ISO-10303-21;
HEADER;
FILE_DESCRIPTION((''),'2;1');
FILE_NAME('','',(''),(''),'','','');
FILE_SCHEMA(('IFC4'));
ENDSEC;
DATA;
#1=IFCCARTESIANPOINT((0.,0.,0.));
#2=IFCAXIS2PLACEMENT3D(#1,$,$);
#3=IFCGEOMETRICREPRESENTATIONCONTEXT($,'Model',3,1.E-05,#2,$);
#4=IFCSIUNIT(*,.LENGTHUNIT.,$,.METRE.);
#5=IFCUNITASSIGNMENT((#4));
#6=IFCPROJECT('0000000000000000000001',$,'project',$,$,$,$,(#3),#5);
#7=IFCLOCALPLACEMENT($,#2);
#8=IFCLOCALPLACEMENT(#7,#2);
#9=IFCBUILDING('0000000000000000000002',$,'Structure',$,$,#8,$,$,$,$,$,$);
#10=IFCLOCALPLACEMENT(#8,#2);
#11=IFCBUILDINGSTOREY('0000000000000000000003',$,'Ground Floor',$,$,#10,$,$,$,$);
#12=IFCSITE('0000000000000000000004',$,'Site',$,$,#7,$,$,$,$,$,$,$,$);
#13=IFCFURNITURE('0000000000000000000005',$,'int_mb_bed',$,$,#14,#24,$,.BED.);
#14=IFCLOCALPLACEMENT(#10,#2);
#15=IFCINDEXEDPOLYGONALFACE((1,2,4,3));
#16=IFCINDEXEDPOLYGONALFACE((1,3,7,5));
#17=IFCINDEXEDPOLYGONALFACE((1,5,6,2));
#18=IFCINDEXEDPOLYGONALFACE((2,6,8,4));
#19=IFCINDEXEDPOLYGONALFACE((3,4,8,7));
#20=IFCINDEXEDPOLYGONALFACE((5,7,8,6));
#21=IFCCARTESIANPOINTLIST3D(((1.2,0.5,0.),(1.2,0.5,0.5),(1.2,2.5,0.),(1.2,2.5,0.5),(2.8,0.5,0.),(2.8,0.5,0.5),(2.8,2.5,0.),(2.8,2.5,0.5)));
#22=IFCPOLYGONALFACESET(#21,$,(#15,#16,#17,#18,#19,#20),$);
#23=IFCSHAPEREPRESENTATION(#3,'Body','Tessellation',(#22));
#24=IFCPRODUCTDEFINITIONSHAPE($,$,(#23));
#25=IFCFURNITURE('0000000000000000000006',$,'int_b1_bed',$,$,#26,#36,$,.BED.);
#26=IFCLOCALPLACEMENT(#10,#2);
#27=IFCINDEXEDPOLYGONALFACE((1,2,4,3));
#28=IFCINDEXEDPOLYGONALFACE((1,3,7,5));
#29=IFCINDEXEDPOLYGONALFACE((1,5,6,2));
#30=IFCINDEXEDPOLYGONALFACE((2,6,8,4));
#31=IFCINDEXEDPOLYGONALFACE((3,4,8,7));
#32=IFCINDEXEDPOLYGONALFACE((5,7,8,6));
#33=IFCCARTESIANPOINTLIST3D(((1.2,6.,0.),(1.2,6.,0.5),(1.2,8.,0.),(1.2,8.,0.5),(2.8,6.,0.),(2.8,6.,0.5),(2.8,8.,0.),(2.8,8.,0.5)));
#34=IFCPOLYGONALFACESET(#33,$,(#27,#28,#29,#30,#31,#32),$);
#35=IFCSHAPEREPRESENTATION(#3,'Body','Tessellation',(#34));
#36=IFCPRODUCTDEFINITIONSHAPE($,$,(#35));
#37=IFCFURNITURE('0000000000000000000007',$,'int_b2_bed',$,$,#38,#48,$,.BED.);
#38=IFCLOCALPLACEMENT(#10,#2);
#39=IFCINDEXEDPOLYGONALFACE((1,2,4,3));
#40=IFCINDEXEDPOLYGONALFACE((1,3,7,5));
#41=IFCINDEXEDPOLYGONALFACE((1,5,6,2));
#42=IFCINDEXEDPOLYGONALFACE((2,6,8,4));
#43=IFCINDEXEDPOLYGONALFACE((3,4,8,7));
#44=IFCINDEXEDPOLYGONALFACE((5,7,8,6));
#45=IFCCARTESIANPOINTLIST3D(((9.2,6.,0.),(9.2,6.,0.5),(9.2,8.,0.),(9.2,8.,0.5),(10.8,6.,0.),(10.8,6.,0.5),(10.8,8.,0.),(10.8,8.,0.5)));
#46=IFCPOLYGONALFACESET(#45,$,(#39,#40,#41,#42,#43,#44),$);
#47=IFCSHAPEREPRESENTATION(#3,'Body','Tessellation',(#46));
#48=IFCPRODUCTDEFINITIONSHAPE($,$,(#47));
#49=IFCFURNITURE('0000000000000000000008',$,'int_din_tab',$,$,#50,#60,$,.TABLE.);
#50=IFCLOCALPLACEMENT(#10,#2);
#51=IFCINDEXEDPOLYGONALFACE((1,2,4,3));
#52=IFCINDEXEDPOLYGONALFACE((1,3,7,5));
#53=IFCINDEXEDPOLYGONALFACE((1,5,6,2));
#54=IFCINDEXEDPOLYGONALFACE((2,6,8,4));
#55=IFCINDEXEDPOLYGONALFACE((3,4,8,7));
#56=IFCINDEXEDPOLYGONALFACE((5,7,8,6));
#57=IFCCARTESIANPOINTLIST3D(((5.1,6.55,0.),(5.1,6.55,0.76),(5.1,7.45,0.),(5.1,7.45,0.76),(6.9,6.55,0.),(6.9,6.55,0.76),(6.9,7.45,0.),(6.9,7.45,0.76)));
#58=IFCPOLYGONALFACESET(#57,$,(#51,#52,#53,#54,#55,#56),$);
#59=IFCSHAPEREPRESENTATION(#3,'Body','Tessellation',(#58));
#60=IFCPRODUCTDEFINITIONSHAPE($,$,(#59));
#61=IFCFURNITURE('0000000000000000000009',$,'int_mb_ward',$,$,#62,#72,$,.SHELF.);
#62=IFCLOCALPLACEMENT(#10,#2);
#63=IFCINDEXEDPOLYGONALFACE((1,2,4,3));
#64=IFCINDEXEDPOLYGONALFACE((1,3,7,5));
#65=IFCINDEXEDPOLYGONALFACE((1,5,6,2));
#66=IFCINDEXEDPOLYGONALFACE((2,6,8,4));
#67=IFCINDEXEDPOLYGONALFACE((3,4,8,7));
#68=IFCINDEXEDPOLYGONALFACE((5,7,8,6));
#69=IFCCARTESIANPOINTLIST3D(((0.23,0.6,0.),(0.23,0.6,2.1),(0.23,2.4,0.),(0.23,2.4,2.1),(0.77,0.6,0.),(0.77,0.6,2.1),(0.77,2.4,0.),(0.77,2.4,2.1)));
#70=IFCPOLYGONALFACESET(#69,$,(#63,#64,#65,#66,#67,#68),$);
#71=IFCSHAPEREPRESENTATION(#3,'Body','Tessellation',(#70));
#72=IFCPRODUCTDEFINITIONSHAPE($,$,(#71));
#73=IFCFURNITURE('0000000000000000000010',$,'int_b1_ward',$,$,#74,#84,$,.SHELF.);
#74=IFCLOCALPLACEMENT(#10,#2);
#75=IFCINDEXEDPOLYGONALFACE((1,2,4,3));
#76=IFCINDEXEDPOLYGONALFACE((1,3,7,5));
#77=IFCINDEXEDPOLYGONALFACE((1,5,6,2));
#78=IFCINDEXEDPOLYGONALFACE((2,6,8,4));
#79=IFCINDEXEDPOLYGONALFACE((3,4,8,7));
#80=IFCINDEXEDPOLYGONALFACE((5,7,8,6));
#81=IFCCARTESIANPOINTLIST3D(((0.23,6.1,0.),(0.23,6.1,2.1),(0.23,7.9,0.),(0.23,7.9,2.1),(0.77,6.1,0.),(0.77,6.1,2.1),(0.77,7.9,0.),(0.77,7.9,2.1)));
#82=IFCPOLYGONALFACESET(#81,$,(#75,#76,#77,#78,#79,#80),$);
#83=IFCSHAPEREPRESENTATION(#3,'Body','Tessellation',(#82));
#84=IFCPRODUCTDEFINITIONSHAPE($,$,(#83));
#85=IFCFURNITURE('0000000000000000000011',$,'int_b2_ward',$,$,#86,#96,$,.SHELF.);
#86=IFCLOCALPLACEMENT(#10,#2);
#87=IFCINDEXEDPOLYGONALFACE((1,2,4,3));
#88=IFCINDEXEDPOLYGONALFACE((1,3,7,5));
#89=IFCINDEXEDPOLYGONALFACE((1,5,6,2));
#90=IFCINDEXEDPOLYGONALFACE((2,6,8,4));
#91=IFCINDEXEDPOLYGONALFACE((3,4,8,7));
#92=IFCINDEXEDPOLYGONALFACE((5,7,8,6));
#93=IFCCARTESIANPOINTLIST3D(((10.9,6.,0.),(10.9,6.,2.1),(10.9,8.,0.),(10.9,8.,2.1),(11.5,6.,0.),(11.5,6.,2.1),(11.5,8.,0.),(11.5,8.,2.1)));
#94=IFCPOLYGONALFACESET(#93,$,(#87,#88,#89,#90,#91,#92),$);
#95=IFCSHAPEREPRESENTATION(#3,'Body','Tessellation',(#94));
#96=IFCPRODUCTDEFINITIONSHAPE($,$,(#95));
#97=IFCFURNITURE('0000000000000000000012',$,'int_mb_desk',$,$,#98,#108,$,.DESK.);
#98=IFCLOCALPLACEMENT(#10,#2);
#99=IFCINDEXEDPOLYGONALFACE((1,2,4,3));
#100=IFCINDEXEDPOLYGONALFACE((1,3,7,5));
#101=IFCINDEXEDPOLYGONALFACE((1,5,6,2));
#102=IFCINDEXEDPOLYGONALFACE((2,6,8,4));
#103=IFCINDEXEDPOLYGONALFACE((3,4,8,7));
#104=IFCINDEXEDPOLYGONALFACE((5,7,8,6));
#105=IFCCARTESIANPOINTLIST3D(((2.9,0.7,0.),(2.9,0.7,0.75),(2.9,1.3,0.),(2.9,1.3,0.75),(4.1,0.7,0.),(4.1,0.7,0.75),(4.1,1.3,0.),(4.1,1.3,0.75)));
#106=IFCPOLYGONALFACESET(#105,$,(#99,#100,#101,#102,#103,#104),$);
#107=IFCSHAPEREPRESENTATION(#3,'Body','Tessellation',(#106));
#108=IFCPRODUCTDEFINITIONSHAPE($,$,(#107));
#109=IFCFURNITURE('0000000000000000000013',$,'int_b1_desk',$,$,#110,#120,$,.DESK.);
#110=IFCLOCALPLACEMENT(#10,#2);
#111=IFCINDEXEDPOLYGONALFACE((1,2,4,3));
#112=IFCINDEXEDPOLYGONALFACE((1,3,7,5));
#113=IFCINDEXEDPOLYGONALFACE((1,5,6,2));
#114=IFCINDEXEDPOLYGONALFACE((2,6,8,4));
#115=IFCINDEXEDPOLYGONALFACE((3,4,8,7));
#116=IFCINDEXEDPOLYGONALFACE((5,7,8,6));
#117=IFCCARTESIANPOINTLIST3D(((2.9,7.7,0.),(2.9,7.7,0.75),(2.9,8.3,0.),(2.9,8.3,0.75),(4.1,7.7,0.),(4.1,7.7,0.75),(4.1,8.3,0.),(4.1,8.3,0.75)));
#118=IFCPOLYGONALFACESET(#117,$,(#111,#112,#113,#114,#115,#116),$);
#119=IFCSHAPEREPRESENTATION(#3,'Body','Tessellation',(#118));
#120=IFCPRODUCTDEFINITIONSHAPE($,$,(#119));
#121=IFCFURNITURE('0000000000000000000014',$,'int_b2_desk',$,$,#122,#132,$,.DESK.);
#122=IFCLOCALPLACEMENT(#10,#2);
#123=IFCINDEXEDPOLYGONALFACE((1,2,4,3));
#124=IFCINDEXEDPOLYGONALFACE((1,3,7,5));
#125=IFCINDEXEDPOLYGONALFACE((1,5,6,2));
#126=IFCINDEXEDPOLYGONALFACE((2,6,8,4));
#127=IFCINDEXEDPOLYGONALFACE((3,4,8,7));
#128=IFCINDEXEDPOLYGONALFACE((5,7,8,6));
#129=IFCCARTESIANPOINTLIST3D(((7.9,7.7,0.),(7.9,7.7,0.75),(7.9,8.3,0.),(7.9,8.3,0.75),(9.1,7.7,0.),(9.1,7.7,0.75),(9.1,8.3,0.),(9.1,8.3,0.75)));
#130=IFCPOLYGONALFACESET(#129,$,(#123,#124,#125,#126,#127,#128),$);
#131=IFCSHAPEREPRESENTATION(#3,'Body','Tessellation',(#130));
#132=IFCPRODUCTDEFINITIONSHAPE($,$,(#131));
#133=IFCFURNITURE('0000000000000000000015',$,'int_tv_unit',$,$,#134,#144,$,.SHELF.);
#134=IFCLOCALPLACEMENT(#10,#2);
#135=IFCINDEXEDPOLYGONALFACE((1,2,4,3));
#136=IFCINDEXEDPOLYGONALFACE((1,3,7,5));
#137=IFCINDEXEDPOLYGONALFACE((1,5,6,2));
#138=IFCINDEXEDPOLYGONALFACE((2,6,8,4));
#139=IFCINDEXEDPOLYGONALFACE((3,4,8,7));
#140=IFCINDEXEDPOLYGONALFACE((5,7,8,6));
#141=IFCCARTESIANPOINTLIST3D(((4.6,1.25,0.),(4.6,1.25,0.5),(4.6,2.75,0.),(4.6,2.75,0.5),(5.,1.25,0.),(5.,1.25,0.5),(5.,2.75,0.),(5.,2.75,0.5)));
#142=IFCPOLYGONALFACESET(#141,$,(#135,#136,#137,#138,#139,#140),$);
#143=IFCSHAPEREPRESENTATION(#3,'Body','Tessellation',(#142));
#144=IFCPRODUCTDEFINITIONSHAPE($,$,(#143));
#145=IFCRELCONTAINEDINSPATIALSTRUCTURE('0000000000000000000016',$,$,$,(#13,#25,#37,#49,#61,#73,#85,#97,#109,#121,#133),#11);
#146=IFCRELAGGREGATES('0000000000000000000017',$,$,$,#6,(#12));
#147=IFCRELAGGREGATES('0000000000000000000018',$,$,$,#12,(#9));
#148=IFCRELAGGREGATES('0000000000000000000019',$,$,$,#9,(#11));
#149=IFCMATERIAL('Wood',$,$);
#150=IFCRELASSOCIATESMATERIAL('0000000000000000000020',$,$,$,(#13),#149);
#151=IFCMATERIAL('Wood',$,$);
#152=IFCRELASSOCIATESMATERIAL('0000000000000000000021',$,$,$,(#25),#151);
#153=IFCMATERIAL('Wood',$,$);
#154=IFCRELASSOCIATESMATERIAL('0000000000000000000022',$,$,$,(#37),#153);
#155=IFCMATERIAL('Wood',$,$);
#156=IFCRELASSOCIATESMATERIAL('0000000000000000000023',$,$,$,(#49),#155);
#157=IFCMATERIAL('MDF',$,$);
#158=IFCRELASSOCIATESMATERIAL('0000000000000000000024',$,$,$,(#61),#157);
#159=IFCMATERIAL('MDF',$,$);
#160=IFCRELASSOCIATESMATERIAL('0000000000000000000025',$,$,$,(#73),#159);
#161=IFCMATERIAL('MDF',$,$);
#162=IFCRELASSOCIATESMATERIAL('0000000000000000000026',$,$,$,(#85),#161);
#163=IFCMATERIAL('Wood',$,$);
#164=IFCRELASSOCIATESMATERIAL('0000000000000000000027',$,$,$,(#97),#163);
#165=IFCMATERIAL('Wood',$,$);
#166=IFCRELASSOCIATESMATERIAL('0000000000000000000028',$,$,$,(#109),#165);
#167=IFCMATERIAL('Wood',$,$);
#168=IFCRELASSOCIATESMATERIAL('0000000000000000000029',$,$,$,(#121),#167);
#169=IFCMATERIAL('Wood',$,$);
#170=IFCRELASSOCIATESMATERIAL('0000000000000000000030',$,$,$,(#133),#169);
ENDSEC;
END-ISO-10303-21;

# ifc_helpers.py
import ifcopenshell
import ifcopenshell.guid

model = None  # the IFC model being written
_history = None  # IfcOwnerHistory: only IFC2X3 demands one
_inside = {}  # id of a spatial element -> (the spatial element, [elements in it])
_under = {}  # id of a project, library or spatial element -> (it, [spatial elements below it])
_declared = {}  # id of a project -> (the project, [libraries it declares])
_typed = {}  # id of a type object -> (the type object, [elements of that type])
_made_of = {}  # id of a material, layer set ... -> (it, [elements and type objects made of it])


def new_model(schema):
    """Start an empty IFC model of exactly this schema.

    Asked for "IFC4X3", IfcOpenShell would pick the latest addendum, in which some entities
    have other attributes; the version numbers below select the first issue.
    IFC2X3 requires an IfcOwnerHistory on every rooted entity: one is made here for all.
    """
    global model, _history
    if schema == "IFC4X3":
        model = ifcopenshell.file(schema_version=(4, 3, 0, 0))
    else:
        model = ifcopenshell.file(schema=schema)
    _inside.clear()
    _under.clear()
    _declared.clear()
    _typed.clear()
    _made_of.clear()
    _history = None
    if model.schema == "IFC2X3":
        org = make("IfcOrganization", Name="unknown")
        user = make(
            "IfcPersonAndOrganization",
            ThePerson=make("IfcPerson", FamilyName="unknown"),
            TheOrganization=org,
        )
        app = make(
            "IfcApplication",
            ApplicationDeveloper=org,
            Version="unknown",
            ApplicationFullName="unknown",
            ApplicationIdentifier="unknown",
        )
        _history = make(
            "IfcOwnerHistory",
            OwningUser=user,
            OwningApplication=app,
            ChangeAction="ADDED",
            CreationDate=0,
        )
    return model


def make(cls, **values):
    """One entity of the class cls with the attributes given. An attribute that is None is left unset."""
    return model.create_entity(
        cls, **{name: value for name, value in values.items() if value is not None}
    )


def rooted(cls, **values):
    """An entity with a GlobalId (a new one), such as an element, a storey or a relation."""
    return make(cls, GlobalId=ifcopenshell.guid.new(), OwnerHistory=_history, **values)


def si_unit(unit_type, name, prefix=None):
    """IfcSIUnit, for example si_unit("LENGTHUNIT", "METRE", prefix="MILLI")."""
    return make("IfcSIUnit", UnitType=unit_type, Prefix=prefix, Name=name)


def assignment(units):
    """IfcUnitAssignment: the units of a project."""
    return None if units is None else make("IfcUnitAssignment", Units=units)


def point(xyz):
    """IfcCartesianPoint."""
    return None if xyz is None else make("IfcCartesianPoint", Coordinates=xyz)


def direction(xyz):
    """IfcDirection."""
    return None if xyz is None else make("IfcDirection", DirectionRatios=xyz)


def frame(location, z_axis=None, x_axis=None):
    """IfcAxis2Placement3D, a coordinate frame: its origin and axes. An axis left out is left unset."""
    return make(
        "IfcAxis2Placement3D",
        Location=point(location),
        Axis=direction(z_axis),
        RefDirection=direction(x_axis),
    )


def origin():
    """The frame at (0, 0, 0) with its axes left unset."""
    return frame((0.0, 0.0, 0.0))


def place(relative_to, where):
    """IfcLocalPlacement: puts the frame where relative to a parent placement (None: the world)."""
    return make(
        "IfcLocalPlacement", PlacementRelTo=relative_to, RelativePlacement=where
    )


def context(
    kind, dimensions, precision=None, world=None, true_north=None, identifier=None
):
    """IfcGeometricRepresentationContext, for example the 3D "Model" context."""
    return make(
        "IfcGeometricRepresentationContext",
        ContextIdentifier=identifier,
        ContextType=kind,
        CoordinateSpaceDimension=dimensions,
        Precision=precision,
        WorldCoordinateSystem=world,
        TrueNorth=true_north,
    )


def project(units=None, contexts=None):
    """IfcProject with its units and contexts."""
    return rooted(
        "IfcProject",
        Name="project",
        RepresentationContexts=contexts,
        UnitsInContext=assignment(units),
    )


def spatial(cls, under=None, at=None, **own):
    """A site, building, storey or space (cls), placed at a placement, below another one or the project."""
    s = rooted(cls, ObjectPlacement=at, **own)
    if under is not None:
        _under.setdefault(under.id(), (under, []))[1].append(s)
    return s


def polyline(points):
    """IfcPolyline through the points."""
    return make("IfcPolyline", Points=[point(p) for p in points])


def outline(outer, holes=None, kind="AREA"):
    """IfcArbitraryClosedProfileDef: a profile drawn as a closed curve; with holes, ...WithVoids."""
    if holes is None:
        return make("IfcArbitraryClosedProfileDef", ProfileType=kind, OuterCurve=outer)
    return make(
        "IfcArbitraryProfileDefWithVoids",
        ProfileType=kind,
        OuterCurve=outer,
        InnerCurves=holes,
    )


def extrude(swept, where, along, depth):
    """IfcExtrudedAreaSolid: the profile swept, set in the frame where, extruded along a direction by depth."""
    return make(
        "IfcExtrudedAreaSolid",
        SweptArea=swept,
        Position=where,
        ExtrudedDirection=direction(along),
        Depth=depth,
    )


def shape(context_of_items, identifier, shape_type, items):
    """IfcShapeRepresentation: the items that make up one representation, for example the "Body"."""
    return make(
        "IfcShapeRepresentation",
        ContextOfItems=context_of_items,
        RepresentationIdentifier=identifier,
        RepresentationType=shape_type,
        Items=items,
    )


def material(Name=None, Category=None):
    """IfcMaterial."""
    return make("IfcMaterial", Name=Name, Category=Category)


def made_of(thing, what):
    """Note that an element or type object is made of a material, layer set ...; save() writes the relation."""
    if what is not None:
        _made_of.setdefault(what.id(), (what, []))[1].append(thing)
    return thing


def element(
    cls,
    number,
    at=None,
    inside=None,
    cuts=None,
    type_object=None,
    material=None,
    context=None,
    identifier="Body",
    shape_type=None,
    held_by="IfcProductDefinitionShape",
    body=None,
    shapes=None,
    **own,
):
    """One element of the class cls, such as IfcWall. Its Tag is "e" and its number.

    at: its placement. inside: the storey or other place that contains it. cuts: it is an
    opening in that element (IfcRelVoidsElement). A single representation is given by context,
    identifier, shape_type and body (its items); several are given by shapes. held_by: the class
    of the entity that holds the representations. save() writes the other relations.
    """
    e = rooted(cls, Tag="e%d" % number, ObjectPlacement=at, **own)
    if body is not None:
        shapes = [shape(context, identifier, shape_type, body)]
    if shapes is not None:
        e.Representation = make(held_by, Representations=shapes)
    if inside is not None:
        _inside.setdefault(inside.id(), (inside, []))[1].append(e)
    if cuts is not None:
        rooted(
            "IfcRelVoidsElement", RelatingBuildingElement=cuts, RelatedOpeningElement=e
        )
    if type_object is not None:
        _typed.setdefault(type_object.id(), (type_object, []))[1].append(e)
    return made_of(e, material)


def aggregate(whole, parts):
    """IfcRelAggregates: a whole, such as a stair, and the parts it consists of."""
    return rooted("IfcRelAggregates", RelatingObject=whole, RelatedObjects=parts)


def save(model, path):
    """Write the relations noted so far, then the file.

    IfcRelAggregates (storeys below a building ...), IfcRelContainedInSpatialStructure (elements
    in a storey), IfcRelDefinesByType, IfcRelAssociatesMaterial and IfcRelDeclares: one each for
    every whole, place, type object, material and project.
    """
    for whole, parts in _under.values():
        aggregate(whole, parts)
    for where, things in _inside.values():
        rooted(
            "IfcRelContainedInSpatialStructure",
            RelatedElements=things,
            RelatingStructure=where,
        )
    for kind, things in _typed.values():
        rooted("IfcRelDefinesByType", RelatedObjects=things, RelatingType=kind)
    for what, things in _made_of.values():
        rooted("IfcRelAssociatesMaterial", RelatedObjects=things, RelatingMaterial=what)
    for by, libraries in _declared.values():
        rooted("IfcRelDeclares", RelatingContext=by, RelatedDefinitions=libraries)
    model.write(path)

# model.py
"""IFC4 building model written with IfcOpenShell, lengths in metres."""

from ifc_helpers import new_model, si_unit, frame, origin, place, context, project, spatial, polyline, outline, extrude, material, element, save


model = new_model("IFC4")

# Units and contexts
model_context = context("Model", 3, precision=1e-05, world=origin())
ifc_project = project(units=[si_unit("LENGTHUNIT", "METRE")], contexts=[model_context])

# Site, building, storey
site_placement = place(None, origin())
site = spatial("IfcSite", under=ifc_project, at=site_placement, Name="Site")
building_placement = place(site_placement, origin())
building = spatial("IfcBuilding", under=site, at=building_placement, Name="Structure")
storey_placement = place(building_placement, origin())
storey = spatial("IfcBuildingStorey", under=building, at=storey_placement, Name="Ground Floor")

# Furniture
ifc_material_1 = material(Name="Wood")
furniture_1_placement = place(storey_placement, frame((2.0, 1.5, 0.0)))
element("IfcFurniture", 1, at=furniture_1_placement, inside=storey, material=ifc_material_1, Name="int_mb_bed", PredefinedType="BED", context=model_context, shape_type="SweptSolid", body=[
    extrude(outline(polyline([(-0.8, -1.0), (0.8, -1.0), (0.8, 1.0), (-0.8, 1.0), (-0.8, -1.0)])), origin(), (0.0, 0.0, 1.0), 0.5),
])
ifc_material_2 = material(Name="Wood")
furniture_2_placement = place(storey_placement, frame((2.0, 7.0, 0.0)))
element("IfcFurniture", 2, at=furniture_2_placement, inside=storey, material=ifc_material_2, Name="int_b1_bed", PredefinedType="BED", context=model_context, shape_type="SweptSolid", body=[
    extrude(outline(polyline([(-0.8, -1.0), (0.8, -1.0), (0.8, 1.0), (-0.8, 1.0), (-0.8, -1.0)])), origin(), (0.0, 0.0, 1.0), 0.5),
])
ifc_material_3 = material(Name="Wood")
furniture_3_placement = place(storey_placement, frame((10.0, 7.0, 0.0)))
element("IfcFurniture", 3, at=furniture_3_placement, inside=storey, material=ifc_material_3, Name="int_b2_bed", PredefinedType="BED", context=model_context, shape_type="SweptSolid", body=[
    extrude(outline(polyline([(-0.8, -1.0), (0.8, -1.0), (0.8, 1.0), (-0.8, 1.0), (-0.8, -1.0)])), origin(), (0.0, 0.0, 1.0), 0.5),
])
ifc_material_4 = material(Name="Wood")
furniture_4_placement = place(storey_placement, frame((6.0, 7.0, 0.0)))
element("IfcFurniture", 4, at=furniture_4_placement, inside=storey, material=ifc_material_4, Name="int_din_tab", PredefinedType="TABLE", context=model_context, shape_type="SweptSolid", body=[
    extrude(outline(polyline([(-0.9, -0.45), (0.9, -0.45), (0.9, 0.45), (-0.9, 0.45), (-0.9, -0.45)])), origin(), (0.0, 0.0, 1.0), 0.76),
])
ifc_material_5 = material(Name="MDF")
furniture_5_placement = place(storey_placement, frame((0.5, 1.5, 0.0)))
element("IfcFurniture", 5, at=furniture_5_placement, inside=storey, material=ifc_material_5, Name="int_mb_ward", PredefinedType="SHELF", context=model_context, shape_type="SweptSolid", body=[
    extrude(outline(polyline([(-0.27, -0.9), (0.27, -0.9), (0.27, 0.9), (-0.27, 0.9), (-0.27, -0.9)])), origin(), (0.0, 0.0, 1.0), 2.1),
])
ifc_material_6 = material(Name="MDF")
furniture_6_placement = place(storey_placement, frame((0.5, 7.0, 0.0)))
element("IfcFurniture", 6, at=furniture_6_placement, inside=storey, material=ifc_material_6, Name="int_b1_ward", PredefinedType="SHELF", context=model_context, shape_type="SweptSolid", body=[
    extrude(outline(polyline([(-0.27, -0.9), (0.27, -0.9), (0.27, 0.9), (-0.27, 0.9), (-0.27, -0.9)])), origin(), (0.0, 0.0, 1.0), 2.1),
])
ifc_material_7 = material(Name="MDF")
furniture_7_placement = place(storey_placement, frame((11.2, 7.0, 0.0)))
element("IfcFurniture", 7, at=furniture_7_placement, inside=storey, material=ifc_material_7, Name="int_b2_ward", PredefinedType="SHELF", context=model_context, shape_type="SweptSolid", body=[
    extrude(outline(polyline([(-0.3, -1.0), (0.3, -1.0), (0.3, 1.0), (-0.3, 1.0), (-0.3, -1.0)])), origin(), (0.0, 0.0, 1.0), 2.1),
])
ifc_material_8 = material(Name="Wood")
furniture_8_placement = place(storey_placement, frame((3.5, 1.0, 0.0)))
element("IfcFurniture", 8, at=furniture_8_placement, inside=storey, material=ifc_material_8, Name="int_mb_desk", PredefinedType="DESK", context=model_context, shape_type="SweptSolid", body=[
    extrude(outline(polyline([(-0.6, -0.3), (0.6, -0.3), (0.6, 0.3), (-0.6, 0.3), (-0.6, -0.3)])), origin(), (0.0, 0.0, 1.0), 0.75),
])
ifc_material_9 = material(Name="Wood")
furniture_9_placement = place(storey_placement, frame((3.5, 8.0, 0.0)))
element("IfcFurniture", 9, at=furniture_9_placement, inside=storey, material=ifc_material_9, Name="int_b1_desk", PredefinedType="DESK", context=model_context, shape_type="SweptSolid", body=[
    extrude(outline(polyline([(-0.6, -0.3), (0.6, -0.3), (0.6, 0.3), (-0.6, 0.3), (-0.6, -0.3)])), origin(), (0.0, 0.0, 1.0), 0.75),
])
ifc_material_10 = material(Name="Wood")
furniture_10_placement = place(storey_placement, frame((8.5, 8.0, 0.0)))
element("IfcFurniture", 10, at=furniture_10_placement, inside=storey, material=ifc_material_10, Name="int_b2_desk", PredefinedType="DESK", context=model_context, shape_type="SweptSolid", body=[
    extrude(outline(polyline([(-0.6, -0.3), (0.6, -0.3), (0.6, 0.3), (-0.6, 0.3), (-0.6, -0.3)])), origin(), (0.0, 0.0, 1.0), 0.75),
])
ifc_material_11 = material(Name="Wood")
furniture_11_placement = place(storey_placement, frame((4.8, 2.0, 0.0)))
element("IfcFurniture", 11, at=furniture_11_placement, inside=storey, material=ifc_material_11, Name="int_tv_unit", PredefinedType="SHELF", context=model_context, shape_type="SweptSolid", body=[
    extrude(outline(polyline([(-0.2, -0.75), (0.2, -0.75), (0.2, 0.75), (-0.2, 0.75), (-0.2, -0.75)])), origin(), (0.0, 0.0, 1.0), 0.5),
])

save(model, "model.ifc")
